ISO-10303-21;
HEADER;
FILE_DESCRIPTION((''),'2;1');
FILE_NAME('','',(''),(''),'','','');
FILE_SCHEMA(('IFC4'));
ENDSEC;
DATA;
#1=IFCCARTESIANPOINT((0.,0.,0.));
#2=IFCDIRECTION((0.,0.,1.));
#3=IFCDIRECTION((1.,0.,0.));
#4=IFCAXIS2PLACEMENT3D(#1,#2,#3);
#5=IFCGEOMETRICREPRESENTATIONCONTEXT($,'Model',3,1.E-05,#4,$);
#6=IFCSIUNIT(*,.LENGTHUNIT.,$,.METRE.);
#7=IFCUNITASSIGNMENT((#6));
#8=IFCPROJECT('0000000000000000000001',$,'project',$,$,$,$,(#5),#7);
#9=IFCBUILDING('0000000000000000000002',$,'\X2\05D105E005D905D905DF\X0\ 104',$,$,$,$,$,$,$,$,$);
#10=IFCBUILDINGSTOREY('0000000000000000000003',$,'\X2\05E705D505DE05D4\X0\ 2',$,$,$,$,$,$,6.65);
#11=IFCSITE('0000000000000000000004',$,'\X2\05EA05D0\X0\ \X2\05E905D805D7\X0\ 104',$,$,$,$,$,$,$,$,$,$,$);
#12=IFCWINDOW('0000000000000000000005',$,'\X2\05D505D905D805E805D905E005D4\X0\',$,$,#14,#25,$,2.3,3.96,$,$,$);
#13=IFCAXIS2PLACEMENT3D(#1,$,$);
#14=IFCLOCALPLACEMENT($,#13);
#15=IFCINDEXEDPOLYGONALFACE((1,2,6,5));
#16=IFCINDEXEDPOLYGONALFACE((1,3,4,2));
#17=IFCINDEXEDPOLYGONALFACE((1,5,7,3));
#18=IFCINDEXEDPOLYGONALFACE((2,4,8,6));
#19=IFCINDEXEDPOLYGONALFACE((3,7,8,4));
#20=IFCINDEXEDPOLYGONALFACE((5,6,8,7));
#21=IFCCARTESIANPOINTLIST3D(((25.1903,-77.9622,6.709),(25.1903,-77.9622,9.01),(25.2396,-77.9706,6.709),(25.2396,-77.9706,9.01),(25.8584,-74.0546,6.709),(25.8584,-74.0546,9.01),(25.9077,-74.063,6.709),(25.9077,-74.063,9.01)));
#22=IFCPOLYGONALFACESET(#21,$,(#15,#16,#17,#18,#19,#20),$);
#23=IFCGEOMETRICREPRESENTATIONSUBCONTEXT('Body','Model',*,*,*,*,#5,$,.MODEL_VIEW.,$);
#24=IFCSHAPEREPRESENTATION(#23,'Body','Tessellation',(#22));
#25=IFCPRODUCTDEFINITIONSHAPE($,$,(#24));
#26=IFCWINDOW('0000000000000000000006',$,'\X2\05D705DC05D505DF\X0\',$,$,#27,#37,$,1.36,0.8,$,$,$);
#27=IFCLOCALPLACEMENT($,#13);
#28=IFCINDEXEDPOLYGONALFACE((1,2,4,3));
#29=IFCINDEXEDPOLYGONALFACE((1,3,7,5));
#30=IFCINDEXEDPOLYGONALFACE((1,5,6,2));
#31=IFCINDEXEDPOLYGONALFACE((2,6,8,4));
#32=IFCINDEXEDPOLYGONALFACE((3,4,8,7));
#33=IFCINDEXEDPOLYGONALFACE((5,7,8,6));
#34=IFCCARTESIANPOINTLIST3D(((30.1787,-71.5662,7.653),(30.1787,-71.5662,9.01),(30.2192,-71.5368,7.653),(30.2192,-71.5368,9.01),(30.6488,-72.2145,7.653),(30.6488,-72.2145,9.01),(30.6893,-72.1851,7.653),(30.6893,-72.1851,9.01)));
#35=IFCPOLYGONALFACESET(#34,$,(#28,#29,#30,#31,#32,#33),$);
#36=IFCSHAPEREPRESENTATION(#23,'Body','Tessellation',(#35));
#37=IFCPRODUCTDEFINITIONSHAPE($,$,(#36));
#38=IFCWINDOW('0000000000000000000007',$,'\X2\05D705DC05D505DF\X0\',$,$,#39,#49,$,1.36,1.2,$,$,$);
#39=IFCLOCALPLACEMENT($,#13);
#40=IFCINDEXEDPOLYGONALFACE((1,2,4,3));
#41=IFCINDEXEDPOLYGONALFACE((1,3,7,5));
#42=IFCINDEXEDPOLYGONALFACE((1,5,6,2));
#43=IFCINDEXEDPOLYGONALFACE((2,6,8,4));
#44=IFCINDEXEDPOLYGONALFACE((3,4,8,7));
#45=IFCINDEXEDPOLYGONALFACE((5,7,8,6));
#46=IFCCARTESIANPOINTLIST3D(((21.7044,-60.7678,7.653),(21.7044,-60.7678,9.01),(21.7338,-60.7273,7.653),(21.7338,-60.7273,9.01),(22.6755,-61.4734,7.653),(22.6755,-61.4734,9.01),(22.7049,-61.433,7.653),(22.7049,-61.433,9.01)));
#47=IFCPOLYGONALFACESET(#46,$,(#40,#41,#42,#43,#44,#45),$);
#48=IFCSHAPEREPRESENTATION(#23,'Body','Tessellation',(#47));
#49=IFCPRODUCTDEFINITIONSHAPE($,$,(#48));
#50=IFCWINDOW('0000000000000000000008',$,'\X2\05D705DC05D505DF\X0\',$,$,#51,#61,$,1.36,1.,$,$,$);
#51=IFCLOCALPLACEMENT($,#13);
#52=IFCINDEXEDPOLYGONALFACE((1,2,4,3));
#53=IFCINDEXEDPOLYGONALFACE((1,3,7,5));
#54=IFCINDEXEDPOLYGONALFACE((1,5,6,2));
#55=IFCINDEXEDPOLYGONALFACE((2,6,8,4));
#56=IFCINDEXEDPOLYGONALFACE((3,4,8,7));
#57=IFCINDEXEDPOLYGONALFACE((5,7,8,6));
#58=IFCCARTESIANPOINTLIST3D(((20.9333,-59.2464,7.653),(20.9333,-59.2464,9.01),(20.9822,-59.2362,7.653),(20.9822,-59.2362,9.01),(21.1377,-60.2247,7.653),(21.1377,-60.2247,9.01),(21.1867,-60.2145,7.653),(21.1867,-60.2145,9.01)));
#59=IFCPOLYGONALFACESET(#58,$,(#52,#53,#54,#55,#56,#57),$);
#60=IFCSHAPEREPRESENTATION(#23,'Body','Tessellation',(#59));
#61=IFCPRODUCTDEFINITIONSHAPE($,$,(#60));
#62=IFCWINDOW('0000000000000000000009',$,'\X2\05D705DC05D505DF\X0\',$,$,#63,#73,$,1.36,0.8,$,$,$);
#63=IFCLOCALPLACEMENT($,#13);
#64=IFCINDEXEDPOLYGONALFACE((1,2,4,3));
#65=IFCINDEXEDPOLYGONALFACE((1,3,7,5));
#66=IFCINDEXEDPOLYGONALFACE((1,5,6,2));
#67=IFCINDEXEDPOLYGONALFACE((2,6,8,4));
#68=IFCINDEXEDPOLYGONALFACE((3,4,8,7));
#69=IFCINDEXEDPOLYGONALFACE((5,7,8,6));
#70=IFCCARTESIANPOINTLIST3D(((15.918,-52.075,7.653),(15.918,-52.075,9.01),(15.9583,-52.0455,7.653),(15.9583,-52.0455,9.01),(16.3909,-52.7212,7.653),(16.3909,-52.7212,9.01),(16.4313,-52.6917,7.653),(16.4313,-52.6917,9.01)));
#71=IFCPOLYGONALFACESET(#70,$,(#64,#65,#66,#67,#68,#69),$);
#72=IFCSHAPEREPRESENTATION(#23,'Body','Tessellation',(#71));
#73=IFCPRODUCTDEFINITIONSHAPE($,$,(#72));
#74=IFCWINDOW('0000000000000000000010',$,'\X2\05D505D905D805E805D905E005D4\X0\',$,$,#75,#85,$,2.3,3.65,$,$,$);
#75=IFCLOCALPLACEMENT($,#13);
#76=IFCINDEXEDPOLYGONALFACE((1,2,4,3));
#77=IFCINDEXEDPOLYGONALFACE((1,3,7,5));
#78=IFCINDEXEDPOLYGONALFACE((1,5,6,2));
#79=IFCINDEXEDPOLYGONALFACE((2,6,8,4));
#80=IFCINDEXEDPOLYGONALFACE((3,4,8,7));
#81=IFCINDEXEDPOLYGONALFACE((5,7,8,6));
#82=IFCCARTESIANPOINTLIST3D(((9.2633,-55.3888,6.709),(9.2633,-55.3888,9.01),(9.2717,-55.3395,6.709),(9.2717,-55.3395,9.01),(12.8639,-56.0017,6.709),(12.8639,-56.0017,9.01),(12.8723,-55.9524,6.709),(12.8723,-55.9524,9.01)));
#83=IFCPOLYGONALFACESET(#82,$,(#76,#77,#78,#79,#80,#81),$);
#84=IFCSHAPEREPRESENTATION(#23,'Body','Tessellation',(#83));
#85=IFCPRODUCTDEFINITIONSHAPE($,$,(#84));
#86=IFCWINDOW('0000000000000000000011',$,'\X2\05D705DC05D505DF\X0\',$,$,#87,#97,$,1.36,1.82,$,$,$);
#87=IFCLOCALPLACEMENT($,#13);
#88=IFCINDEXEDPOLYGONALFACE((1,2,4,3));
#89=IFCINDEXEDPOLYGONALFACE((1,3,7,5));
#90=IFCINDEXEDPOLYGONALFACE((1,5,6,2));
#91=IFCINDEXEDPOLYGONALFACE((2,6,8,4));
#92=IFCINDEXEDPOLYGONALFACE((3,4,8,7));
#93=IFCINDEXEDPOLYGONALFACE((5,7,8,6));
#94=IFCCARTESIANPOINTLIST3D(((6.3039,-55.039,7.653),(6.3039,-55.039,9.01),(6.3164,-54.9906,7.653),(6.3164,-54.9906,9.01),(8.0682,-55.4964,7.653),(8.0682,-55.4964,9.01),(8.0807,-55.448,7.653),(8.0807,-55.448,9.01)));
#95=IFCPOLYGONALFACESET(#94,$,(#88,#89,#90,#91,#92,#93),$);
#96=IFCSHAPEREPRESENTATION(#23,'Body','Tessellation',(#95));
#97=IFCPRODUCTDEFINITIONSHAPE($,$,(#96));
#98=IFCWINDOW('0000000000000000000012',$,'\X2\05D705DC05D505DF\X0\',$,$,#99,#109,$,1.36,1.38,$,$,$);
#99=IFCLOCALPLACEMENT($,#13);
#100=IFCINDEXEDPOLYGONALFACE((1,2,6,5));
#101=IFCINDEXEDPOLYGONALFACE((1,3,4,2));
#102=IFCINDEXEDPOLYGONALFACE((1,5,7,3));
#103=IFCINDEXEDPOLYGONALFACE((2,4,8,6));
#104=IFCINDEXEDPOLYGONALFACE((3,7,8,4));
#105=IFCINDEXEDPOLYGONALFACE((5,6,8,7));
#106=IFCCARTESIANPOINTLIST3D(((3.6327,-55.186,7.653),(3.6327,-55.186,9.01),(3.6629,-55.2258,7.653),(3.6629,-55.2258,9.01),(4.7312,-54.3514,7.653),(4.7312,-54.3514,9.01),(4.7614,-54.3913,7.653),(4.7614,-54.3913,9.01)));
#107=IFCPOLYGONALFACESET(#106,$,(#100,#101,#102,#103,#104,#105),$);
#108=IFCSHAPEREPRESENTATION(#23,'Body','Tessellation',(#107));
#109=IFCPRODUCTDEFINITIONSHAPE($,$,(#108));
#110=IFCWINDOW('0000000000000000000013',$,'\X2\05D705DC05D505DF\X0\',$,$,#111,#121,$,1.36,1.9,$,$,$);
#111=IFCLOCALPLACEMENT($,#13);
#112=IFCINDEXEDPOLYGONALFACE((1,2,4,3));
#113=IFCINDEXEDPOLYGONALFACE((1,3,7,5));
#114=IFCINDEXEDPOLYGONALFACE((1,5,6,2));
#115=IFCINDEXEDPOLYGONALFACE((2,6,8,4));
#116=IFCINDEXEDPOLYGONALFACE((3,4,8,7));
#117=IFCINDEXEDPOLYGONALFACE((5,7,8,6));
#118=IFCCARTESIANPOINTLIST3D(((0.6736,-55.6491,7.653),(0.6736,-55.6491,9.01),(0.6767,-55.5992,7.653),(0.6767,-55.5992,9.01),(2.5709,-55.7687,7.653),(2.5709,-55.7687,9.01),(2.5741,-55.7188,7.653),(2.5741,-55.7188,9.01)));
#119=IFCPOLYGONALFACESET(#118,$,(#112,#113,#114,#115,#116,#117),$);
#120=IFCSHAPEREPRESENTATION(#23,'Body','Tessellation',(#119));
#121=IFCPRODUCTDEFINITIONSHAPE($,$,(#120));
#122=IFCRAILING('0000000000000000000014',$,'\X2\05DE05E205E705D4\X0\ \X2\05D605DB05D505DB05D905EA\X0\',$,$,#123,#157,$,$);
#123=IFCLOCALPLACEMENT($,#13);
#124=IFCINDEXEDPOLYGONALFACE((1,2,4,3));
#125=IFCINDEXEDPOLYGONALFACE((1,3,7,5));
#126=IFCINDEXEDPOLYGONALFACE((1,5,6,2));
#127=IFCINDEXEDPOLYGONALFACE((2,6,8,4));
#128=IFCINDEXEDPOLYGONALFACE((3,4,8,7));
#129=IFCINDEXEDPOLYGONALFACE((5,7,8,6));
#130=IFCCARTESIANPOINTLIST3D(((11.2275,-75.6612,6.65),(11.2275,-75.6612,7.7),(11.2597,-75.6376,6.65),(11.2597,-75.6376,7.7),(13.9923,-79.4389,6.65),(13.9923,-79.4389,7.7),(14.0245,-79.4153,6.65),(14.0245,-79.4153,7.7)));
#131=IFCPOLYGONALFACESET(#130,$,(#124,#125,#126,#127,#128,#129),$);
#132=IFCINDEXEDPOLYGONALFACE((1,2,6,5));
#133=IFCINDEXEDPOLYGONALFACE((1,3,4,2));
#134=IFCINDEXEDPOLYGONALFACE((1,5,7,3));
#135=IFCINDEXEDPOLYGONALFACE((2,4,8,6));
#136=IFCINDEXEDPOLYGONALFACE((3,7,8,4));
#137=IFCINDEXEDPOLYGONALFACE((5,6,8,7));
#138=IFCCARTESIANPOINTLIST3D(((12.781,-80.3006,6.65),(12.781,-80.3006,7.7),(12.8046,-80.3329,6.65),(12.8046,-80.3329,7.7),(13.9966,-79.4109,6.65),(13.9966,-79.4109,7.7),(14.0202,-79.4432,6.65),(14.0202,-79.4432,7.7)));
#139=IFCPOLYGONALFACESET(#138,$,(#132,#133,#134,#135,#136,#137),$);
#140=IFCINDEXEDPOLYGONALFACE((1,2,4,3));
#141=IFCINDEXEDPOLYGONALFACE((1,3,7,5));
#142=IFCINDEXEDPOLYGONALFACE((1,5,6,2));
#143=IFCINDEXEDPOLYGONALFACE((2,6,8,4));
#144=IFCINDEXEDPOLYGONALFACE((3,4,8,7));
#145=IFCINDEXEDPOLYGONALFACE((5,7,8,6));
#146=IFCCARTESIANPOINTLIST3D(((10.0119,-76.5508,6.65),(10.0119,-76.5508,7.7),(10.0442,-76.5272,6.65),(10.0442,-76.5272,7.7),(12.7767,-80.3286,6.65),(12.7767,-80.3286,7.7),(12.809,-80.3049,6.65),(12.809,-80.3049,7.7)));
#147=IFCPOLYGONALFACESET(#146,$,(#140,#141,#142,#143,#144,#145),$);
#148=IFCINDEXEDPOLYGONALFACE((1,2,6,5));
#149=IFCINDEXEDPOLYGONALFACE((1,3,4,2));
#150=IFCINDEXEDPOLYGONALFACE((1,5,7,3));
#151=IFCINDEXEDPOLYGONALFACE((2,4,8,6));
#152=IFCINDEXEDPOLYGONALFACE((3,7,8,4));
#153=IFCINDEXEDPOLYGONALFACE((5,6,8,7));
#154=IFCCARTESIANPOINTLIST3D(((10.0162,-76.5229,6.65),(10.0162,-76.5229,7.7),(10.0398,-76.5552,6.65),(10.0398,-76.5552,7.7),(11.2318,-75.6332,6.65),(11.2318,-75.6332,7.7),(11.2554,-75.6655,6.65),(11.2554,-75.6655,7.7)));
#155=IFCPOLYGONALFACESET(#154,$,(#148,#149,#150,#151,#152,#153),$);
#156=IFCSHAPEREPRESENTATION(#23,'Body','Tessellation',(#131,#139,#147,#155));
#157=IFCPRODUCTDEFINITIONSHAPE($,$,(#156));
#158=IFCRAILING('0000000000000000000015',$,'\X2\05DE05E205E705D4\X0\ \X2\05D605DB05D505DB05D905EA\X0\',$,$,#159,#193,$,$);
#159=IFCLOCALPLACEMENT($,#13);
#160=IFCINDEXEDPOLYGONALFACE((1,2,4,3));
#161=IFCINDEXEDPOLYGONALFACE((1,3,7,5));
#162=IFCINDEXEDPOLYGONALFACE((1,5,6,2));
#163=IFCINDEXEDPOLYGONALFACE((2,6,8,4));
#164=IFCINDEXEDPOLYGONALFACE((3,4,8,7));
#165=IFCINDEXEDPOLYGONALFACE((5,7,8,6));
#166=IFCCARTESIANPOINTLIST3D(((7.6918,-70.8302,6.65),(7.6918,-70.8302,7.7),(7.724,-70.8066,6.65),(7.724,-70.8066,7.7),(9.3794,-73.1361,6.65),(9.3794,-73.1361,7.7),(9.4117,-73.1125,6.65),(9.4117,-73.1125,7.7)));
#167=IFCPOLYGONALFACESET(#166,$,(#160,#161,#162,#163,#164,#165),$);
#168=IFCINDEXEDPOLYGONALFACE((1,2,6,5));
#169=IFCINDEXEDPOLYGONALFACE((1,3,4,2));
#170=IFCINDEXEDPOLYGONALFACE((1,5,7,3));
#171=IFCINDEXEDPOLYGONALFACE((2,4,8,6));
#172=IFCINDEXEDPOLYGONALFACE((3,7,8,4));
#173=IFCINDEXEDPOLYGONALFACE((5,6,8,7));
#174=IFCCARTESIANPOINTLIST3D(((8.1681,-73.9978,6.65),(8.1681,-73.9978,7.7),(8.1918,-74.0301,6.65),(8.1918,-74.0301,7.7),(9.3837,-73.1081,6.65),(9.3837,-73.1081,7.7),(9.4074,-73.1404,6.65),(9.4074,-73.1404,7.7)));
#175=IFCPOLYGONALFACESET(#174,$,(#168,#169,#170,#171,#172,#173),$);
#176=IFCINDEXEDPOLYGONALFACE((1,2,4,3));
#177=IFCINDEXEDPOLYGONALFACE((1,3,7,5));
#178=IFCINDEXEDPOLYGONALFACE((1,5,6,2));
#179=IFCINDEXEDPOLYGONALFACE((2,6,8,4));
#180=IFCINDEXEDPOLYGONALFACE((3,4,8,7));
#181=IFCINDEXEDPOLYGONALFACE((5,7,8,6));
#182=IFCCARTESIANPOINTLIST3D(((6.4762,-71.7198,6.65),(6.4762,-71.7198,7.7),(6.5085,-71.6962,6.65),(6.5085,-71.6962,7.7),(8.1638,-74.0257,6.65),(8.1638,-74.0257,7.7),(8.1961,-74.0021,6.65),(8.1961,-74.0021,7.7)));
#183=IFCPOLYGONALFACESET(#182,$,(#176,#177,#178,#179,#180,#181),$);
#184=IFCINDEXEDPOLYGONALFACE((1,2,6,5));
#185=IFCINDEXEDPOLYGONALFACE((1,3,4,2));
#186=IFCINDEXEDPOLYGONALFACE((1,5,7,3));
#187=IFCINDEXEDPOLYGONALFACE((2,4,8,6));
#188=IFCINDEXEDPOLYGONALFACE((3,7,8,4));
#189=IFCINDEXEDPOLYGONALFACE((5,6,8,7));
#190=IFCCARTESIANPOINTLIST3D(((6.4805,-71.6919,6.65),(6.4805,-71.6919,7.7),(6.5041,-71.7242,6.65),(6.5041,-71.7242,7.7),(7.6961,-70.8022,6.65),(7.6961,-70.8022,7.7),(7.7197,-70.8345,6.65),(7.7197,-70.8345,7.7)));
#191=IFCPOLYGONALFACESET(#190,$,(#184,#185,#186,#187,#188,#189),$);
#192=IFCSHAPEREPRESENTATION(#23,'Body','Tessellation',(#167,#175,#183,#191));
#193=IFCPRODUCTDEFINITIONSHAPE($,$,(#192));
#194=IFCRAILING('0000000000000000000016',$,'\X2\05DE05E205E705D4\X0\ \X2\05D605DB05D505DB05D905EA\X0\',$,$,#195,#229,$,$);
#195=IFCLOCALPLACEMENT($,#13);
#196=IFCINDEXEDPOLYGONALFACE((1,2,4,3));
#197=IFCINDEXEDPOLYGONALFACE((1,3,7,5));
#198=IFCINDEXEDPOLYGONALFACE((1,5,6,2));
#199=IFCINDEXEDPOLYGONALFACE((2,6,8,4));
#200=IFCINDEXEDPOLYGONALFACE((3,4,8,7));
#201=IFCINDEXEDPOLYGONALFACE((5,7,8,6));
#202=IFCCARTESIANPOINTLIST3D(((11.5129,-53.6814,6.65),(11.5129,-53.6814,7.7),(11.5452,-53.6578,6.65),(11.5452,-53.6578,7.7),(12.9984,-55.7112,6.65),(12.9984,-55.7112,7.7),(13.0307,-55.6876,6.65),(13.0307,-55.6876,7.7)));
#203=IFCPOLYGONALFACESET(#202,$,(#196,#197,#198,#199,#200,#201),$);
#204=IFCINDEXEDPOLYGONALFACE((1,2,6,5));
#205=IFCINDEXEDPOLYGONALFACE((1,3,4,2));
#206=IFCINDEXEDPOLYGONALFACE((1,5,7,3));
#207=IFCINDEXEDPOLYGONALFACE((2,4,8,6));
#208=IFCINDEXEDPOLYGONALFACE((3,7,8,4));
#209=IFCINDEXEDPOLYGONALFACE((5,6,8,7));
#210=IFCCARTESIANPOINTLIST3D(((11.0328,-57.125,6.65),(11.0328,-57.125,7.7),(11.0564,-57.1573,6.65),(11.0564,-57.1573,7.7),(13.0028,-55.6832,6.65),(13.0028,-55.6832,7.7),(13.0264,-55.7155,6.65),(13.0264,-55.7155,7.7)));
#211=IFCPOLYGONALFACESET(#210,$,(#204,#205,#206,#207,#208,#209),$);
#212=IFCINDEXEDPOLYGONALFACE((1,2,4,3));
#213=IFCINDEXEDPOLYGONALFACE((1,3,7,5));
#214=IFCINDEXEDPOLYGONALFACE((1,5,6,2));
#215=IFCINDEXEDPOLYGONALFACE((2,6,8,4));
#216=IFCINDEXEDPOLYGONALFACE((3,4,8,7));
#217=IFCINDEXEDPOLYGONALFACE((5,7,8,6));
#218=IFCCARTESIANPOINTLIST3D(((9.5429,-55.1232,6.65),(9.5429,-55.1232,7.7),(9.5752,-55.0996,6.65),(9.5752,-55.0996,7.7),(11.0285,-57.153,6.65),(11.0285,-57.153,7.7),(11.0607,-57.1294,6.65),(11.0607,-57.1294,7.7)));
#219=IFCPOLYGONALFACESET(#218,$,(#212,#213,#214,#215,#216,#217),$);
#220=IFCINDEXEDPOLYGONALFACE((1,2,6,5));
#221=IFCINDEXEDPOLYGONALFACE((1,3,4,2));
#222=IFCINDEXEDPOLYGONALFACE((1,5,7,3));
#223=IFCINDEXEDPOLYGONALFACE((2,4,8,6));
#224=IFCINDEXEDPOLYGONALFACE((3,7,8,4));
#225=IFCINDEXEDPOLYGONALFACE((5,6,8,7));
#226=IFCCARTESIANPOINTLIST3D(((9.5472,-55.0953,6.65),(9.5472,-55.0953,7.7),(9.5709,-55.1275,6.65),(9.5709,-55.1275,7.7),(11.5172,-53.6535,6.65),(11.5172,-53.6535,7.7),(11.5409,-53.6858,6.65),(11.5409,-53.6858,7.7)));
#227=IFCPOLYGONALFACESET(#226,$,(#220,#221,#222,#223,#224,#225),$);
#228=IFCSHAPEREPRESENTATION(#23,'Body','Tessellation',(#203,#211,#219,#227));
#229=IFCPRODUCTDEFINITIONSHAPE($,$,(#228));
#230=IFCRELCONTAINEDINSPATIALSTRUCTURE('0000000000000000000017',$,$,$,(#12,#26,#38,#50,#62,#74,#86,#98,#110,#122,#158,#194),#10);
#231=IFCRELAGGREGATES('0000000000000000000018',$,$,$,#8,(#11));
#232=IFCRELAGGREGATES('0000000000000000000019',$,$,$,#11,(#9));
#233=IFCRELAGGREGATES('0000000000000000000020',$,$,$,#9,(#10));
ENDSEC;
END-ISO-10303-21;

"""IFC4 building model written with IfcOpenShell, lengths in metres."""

from ifc_helpers import new_model, si_unit, frame, origin_with_axes, context, subcontext, project, spatial, polyline, outline, extrude, element, save


model = new_model("IFC4")

# Units and contexts
model_context = context("Model", 3, precision=1e-05, world=origin_with_axes())
body_context = subcontext(model_context, "Body", "Model", "MODEL_VIEW")
ifc_project = project(units=[si_unit("LENGTHUNIT", "METRE")], contexts=[model_context])

# Site, building, storey
site = spatial("IfcSite", under=ifc_project, Name="תא שטח 104")
building = spatial("IfcBuilding", under=site, Name="בניין 104")
storey = spatial("IfcBuildingStorey", under=building, Name="קומה 2", Elevation=6.65)

# Windows
element("IfcWindow", 1, inside=storey, Name="ויטרינה", OverallHeight=2.3, OverallWidth=3.96, context=body_context, shape_type="SweptSolid", body=[
    extrude(outline(polyline([(25.2396, -77.9706), (25.9077, -74.063), (25.8584, -74.0546), (25.1903, -77.9622), (25.2396, -77.9706)])), frame((0.0, 0.0, 6.709)), (0.0, 0.0, 1.0), 2.301),
])
element("IfcWindow", 2, inside=storey, Name="חלון", OverallHeight=1.36, OverallWidth=0.8, context=body_context, shape_type="SweptSolid", body=[
    extrude(outline(polyline([(30.6893, -72.1851), (30.2192, -71.5368), (30.1787, -71.5662), (30.6488, -72.2145), (30.6893, -72.1851)])), frame((0.0, 0.0, 7.653)), (0.0, 0.0, 1.0), 1.357),
])
element("IfcWindow", 3, inside=storey, Name="חלון", OverallHeight=1.36, OverallWidth=1.2, context=body_context, shape_type="SweptSolid", body=[
    extrude(outline(polyline([(22.7049, -61.433), (21.7338, -60.7273), (21.7044, -60.7678), (22.6755, -61.4734), (22.7049, -61.433)])), frame((0.0, 0.0, 7.653)), (0.0, 0.0, 1.0), 1.357),
])
element("IfcWindow", 4, inside=storey, Name="חלון", OverallHeight=1.36, OverallWidth=1.0, context=body_context, shape_type="SweptSolid", body=[
    extrude(outline(polyline([(21.1867, -60.2145), (20.9822, -59.2362), (20.9333, -59.2464), (21.1377, -60.2247), (21.1867, -60.2145)])), frame((0.0, 0.0, 7.653)), (0.0, 0.0, 1.0), 1.357),
])
element("IfcWindow", 5, inside=storey, Name="חלון", OverallHeight=1.36, OverallWidth=0.8, context=body_context, shape_type="SweptSolid", body=[
    extrude(outline(polyline([(16.4313, -52.6917), (15.9583, -52.0455), (15.918, -52.075), (16.3909, -52.7212), (16.4313, -52.6917)])), frame((0.0, 0.0, 7.653)), (0.0, 0.0, 1.0), 1.357),
])
element("IfcWindow", 6, inside=storey, Name="ויטרינה", OverallHeight=2.3, OverallWidth=3.65, context=body_context, shape_type="SweptSolid", body=[
    extrude(outline(polyline([(12.8723, -55.9524), (9.2717, -55.3395), (9.2633, -55.3888), (12.8639, -56.0017), (12.8723, -55.9524)])), frame((0.0, 0.0, 6.709)), (0.0, 0.0, 1.0), 2.301),
])
element("IfcWindow", 7, inside=storey, Name="חלון", OverallHeight=1.36, OverallWidth=1.82, context=body_context, shape_type="SweptSolid", body=[
    extrude(outline(polyline([(8.0807, -55.448), (6.3164, -54.9906), (6.3039, -55.039), (8.0682, -55.4964), (8.0807, -55.448)])), frame((0.0, 0.0, 7.653)), (0.0, 0.0, 1.0), 1.357),
])
element("IfcWindow", 8, inside=storey, Name="חלון", OverallHeight=1.36, OverallWidth=1.38, context=body_context, shape_type="SweptSolid", body=[
    extrude(outline(polyline([(4.7312, -54.3514), (3.6327, -55.186), (3.6629, -55.2258), (4.7614, -54.3913), (4.7312, -54.3514)])), frame((0.0, 0.0, 7.653)), (0.0, 0.0, 1.0), 1.357),
])
element("IfcWindow", 9, inside=storey, Name="חלון", OverallHeight=1.36, OverallWidth=1.9, context=body_context, shape_type="SweptSolid", body=[
    extrude(outline(polyline([(2.5741, -55.7188), (0.6767, -55.5992), (0.6736, -55.6491), (2.5709, -55.7687), (2.5741, -55.7188)])), frame((0.0, 0.0, 7.653)), (0.0, 0.0, 1.0), 1.357),
])

# Railings
element("IfcRailing", 10, inside=storey, Name="מעקה זכוכית", context=body_context, shape_type="SweptSolid", body=[
    extrude(outline(polyline([(11.2275, -75.6612), (13.9923, -79.4389), (14.0245, -79.4153), (11.2597, -75.6376), (11.2275, -75.6612)])), frame((0.0, 0.0, 6.65)), (0.0, 0.0, 1.0), 1.05),
    extrude(outline(polyline([(13.9966, -79.4109), (12.781, -80.3006), (12.8046, -80.3329), (14.0202, -79.4432), (13.9966, -79.4109)])), frame((0.0, 0.0, 6.65)), (0.0, 0.0, 1.0), 1.05),
    extrude(outline(polyline([(12.809, -80.3049), (10.0442, -76.5272), (10.0119, -76.5508), (12.7767, -80.3286), (12.809, -80.3049)])), frame((0.0, 0.0, 6.65)), (0.0, 0.0, 1.0), 1.05),
    extrude(outline(polyline([(10.0398, -76.5552), (11.2554, -75.6655), (11.2318, -75.6332), (10.0162, -76.5229), (10.0398, -76.5552)])), frame((0.0, 0.0, 6.65)), (0.0, 0.0, 1.0), 1.05),
])
element("IfcRailing", 11, inside=storey, Name="מעקה זכוכית", context=body_context, shape_type="SweptSolid", body=[
    extrude(outline(polyline([(7.6918, -70.8302), (9.3794, -73.1361), (9.4117, -73.1125), (7.724, -70.8066), (7.6918, -70.8302)])), frame((0.0, 0.0, 6.65)), (0.0, 0.0, 1.0), 1.05),
    extrude(outline(polyline([(9.3837, -73.1081), (8.1681, -73.9978), (8.1918, -74.0301), (9.4074, -73.1404), (9.3837, -73.1081)])), frame((0.0, 0.0, 6.65)), (0.0, 0.0, 1.0), 1.05),
    extrude(outline(polyline([(8.1961, -74.0021), (6.5085, -71.6962), (6.4762, -71.7198), (8.1638, -74.0257), (8.1961, -74.0021)])), frame((0.0, 0.0, 6.65)), (0.0, 0.0, 1.0), 1.05),
    extrude(outline(polyline([(6.5041, -71.7242), (7.7197, -70.8345), (7.6961, -70.8022), (6.4805, -71.6919), (6.5041, -71.7242)])), frame((0.0, 0.0, 6.65)), (0.0, 0.0, 1.0), 1.05),
])
element("IfcRailing", 12, inside=storey, Name="מעקה זכוכית", context=body_context, shape_type="SweptSolid", body=[
    extrude(outline(polyline([(11.5129, -53.6814), (12.9984, -55.7112), (13.0307, -55.6876), (11.5452, -53.6578), (11.5129, -53.6814)])), frame((0.0, 0.0, 6.65)), (0.0, 0.0, 1.0), 1.05),
    extrude(outline(polyline([(13.0028, -55.6832), (11.0328, -57.125), (11.0564, -57.1573), (13.0264, -55.7155), (13.0028, -55.6832)])), frame((0.0, 0.0, 6.65)), (0.0, 0.0, 1.0), 1.05),
    extrude(outline(polyline([(11.0607, -57.1294), (9.5752, -55.0996), (9.5429, -55.1232), (11.0285, -57.153), (11.0607, -57.1294)])), frame((0.0, 0.0, 6.65)), (0.0, 0.0, 1.0), 1.05),
    extrude(outline(polyline([(9.5709, -55.1275), (11.5409, -53.6858), (11.5172, -53.6535), (9.5472, -55.0953), (9.5709, -55.1275)])), frame((0.0, 0.0, 6.65)), (0.0, 0.0, 1.0), 1.05),
])

save(model, "model.ifc")
